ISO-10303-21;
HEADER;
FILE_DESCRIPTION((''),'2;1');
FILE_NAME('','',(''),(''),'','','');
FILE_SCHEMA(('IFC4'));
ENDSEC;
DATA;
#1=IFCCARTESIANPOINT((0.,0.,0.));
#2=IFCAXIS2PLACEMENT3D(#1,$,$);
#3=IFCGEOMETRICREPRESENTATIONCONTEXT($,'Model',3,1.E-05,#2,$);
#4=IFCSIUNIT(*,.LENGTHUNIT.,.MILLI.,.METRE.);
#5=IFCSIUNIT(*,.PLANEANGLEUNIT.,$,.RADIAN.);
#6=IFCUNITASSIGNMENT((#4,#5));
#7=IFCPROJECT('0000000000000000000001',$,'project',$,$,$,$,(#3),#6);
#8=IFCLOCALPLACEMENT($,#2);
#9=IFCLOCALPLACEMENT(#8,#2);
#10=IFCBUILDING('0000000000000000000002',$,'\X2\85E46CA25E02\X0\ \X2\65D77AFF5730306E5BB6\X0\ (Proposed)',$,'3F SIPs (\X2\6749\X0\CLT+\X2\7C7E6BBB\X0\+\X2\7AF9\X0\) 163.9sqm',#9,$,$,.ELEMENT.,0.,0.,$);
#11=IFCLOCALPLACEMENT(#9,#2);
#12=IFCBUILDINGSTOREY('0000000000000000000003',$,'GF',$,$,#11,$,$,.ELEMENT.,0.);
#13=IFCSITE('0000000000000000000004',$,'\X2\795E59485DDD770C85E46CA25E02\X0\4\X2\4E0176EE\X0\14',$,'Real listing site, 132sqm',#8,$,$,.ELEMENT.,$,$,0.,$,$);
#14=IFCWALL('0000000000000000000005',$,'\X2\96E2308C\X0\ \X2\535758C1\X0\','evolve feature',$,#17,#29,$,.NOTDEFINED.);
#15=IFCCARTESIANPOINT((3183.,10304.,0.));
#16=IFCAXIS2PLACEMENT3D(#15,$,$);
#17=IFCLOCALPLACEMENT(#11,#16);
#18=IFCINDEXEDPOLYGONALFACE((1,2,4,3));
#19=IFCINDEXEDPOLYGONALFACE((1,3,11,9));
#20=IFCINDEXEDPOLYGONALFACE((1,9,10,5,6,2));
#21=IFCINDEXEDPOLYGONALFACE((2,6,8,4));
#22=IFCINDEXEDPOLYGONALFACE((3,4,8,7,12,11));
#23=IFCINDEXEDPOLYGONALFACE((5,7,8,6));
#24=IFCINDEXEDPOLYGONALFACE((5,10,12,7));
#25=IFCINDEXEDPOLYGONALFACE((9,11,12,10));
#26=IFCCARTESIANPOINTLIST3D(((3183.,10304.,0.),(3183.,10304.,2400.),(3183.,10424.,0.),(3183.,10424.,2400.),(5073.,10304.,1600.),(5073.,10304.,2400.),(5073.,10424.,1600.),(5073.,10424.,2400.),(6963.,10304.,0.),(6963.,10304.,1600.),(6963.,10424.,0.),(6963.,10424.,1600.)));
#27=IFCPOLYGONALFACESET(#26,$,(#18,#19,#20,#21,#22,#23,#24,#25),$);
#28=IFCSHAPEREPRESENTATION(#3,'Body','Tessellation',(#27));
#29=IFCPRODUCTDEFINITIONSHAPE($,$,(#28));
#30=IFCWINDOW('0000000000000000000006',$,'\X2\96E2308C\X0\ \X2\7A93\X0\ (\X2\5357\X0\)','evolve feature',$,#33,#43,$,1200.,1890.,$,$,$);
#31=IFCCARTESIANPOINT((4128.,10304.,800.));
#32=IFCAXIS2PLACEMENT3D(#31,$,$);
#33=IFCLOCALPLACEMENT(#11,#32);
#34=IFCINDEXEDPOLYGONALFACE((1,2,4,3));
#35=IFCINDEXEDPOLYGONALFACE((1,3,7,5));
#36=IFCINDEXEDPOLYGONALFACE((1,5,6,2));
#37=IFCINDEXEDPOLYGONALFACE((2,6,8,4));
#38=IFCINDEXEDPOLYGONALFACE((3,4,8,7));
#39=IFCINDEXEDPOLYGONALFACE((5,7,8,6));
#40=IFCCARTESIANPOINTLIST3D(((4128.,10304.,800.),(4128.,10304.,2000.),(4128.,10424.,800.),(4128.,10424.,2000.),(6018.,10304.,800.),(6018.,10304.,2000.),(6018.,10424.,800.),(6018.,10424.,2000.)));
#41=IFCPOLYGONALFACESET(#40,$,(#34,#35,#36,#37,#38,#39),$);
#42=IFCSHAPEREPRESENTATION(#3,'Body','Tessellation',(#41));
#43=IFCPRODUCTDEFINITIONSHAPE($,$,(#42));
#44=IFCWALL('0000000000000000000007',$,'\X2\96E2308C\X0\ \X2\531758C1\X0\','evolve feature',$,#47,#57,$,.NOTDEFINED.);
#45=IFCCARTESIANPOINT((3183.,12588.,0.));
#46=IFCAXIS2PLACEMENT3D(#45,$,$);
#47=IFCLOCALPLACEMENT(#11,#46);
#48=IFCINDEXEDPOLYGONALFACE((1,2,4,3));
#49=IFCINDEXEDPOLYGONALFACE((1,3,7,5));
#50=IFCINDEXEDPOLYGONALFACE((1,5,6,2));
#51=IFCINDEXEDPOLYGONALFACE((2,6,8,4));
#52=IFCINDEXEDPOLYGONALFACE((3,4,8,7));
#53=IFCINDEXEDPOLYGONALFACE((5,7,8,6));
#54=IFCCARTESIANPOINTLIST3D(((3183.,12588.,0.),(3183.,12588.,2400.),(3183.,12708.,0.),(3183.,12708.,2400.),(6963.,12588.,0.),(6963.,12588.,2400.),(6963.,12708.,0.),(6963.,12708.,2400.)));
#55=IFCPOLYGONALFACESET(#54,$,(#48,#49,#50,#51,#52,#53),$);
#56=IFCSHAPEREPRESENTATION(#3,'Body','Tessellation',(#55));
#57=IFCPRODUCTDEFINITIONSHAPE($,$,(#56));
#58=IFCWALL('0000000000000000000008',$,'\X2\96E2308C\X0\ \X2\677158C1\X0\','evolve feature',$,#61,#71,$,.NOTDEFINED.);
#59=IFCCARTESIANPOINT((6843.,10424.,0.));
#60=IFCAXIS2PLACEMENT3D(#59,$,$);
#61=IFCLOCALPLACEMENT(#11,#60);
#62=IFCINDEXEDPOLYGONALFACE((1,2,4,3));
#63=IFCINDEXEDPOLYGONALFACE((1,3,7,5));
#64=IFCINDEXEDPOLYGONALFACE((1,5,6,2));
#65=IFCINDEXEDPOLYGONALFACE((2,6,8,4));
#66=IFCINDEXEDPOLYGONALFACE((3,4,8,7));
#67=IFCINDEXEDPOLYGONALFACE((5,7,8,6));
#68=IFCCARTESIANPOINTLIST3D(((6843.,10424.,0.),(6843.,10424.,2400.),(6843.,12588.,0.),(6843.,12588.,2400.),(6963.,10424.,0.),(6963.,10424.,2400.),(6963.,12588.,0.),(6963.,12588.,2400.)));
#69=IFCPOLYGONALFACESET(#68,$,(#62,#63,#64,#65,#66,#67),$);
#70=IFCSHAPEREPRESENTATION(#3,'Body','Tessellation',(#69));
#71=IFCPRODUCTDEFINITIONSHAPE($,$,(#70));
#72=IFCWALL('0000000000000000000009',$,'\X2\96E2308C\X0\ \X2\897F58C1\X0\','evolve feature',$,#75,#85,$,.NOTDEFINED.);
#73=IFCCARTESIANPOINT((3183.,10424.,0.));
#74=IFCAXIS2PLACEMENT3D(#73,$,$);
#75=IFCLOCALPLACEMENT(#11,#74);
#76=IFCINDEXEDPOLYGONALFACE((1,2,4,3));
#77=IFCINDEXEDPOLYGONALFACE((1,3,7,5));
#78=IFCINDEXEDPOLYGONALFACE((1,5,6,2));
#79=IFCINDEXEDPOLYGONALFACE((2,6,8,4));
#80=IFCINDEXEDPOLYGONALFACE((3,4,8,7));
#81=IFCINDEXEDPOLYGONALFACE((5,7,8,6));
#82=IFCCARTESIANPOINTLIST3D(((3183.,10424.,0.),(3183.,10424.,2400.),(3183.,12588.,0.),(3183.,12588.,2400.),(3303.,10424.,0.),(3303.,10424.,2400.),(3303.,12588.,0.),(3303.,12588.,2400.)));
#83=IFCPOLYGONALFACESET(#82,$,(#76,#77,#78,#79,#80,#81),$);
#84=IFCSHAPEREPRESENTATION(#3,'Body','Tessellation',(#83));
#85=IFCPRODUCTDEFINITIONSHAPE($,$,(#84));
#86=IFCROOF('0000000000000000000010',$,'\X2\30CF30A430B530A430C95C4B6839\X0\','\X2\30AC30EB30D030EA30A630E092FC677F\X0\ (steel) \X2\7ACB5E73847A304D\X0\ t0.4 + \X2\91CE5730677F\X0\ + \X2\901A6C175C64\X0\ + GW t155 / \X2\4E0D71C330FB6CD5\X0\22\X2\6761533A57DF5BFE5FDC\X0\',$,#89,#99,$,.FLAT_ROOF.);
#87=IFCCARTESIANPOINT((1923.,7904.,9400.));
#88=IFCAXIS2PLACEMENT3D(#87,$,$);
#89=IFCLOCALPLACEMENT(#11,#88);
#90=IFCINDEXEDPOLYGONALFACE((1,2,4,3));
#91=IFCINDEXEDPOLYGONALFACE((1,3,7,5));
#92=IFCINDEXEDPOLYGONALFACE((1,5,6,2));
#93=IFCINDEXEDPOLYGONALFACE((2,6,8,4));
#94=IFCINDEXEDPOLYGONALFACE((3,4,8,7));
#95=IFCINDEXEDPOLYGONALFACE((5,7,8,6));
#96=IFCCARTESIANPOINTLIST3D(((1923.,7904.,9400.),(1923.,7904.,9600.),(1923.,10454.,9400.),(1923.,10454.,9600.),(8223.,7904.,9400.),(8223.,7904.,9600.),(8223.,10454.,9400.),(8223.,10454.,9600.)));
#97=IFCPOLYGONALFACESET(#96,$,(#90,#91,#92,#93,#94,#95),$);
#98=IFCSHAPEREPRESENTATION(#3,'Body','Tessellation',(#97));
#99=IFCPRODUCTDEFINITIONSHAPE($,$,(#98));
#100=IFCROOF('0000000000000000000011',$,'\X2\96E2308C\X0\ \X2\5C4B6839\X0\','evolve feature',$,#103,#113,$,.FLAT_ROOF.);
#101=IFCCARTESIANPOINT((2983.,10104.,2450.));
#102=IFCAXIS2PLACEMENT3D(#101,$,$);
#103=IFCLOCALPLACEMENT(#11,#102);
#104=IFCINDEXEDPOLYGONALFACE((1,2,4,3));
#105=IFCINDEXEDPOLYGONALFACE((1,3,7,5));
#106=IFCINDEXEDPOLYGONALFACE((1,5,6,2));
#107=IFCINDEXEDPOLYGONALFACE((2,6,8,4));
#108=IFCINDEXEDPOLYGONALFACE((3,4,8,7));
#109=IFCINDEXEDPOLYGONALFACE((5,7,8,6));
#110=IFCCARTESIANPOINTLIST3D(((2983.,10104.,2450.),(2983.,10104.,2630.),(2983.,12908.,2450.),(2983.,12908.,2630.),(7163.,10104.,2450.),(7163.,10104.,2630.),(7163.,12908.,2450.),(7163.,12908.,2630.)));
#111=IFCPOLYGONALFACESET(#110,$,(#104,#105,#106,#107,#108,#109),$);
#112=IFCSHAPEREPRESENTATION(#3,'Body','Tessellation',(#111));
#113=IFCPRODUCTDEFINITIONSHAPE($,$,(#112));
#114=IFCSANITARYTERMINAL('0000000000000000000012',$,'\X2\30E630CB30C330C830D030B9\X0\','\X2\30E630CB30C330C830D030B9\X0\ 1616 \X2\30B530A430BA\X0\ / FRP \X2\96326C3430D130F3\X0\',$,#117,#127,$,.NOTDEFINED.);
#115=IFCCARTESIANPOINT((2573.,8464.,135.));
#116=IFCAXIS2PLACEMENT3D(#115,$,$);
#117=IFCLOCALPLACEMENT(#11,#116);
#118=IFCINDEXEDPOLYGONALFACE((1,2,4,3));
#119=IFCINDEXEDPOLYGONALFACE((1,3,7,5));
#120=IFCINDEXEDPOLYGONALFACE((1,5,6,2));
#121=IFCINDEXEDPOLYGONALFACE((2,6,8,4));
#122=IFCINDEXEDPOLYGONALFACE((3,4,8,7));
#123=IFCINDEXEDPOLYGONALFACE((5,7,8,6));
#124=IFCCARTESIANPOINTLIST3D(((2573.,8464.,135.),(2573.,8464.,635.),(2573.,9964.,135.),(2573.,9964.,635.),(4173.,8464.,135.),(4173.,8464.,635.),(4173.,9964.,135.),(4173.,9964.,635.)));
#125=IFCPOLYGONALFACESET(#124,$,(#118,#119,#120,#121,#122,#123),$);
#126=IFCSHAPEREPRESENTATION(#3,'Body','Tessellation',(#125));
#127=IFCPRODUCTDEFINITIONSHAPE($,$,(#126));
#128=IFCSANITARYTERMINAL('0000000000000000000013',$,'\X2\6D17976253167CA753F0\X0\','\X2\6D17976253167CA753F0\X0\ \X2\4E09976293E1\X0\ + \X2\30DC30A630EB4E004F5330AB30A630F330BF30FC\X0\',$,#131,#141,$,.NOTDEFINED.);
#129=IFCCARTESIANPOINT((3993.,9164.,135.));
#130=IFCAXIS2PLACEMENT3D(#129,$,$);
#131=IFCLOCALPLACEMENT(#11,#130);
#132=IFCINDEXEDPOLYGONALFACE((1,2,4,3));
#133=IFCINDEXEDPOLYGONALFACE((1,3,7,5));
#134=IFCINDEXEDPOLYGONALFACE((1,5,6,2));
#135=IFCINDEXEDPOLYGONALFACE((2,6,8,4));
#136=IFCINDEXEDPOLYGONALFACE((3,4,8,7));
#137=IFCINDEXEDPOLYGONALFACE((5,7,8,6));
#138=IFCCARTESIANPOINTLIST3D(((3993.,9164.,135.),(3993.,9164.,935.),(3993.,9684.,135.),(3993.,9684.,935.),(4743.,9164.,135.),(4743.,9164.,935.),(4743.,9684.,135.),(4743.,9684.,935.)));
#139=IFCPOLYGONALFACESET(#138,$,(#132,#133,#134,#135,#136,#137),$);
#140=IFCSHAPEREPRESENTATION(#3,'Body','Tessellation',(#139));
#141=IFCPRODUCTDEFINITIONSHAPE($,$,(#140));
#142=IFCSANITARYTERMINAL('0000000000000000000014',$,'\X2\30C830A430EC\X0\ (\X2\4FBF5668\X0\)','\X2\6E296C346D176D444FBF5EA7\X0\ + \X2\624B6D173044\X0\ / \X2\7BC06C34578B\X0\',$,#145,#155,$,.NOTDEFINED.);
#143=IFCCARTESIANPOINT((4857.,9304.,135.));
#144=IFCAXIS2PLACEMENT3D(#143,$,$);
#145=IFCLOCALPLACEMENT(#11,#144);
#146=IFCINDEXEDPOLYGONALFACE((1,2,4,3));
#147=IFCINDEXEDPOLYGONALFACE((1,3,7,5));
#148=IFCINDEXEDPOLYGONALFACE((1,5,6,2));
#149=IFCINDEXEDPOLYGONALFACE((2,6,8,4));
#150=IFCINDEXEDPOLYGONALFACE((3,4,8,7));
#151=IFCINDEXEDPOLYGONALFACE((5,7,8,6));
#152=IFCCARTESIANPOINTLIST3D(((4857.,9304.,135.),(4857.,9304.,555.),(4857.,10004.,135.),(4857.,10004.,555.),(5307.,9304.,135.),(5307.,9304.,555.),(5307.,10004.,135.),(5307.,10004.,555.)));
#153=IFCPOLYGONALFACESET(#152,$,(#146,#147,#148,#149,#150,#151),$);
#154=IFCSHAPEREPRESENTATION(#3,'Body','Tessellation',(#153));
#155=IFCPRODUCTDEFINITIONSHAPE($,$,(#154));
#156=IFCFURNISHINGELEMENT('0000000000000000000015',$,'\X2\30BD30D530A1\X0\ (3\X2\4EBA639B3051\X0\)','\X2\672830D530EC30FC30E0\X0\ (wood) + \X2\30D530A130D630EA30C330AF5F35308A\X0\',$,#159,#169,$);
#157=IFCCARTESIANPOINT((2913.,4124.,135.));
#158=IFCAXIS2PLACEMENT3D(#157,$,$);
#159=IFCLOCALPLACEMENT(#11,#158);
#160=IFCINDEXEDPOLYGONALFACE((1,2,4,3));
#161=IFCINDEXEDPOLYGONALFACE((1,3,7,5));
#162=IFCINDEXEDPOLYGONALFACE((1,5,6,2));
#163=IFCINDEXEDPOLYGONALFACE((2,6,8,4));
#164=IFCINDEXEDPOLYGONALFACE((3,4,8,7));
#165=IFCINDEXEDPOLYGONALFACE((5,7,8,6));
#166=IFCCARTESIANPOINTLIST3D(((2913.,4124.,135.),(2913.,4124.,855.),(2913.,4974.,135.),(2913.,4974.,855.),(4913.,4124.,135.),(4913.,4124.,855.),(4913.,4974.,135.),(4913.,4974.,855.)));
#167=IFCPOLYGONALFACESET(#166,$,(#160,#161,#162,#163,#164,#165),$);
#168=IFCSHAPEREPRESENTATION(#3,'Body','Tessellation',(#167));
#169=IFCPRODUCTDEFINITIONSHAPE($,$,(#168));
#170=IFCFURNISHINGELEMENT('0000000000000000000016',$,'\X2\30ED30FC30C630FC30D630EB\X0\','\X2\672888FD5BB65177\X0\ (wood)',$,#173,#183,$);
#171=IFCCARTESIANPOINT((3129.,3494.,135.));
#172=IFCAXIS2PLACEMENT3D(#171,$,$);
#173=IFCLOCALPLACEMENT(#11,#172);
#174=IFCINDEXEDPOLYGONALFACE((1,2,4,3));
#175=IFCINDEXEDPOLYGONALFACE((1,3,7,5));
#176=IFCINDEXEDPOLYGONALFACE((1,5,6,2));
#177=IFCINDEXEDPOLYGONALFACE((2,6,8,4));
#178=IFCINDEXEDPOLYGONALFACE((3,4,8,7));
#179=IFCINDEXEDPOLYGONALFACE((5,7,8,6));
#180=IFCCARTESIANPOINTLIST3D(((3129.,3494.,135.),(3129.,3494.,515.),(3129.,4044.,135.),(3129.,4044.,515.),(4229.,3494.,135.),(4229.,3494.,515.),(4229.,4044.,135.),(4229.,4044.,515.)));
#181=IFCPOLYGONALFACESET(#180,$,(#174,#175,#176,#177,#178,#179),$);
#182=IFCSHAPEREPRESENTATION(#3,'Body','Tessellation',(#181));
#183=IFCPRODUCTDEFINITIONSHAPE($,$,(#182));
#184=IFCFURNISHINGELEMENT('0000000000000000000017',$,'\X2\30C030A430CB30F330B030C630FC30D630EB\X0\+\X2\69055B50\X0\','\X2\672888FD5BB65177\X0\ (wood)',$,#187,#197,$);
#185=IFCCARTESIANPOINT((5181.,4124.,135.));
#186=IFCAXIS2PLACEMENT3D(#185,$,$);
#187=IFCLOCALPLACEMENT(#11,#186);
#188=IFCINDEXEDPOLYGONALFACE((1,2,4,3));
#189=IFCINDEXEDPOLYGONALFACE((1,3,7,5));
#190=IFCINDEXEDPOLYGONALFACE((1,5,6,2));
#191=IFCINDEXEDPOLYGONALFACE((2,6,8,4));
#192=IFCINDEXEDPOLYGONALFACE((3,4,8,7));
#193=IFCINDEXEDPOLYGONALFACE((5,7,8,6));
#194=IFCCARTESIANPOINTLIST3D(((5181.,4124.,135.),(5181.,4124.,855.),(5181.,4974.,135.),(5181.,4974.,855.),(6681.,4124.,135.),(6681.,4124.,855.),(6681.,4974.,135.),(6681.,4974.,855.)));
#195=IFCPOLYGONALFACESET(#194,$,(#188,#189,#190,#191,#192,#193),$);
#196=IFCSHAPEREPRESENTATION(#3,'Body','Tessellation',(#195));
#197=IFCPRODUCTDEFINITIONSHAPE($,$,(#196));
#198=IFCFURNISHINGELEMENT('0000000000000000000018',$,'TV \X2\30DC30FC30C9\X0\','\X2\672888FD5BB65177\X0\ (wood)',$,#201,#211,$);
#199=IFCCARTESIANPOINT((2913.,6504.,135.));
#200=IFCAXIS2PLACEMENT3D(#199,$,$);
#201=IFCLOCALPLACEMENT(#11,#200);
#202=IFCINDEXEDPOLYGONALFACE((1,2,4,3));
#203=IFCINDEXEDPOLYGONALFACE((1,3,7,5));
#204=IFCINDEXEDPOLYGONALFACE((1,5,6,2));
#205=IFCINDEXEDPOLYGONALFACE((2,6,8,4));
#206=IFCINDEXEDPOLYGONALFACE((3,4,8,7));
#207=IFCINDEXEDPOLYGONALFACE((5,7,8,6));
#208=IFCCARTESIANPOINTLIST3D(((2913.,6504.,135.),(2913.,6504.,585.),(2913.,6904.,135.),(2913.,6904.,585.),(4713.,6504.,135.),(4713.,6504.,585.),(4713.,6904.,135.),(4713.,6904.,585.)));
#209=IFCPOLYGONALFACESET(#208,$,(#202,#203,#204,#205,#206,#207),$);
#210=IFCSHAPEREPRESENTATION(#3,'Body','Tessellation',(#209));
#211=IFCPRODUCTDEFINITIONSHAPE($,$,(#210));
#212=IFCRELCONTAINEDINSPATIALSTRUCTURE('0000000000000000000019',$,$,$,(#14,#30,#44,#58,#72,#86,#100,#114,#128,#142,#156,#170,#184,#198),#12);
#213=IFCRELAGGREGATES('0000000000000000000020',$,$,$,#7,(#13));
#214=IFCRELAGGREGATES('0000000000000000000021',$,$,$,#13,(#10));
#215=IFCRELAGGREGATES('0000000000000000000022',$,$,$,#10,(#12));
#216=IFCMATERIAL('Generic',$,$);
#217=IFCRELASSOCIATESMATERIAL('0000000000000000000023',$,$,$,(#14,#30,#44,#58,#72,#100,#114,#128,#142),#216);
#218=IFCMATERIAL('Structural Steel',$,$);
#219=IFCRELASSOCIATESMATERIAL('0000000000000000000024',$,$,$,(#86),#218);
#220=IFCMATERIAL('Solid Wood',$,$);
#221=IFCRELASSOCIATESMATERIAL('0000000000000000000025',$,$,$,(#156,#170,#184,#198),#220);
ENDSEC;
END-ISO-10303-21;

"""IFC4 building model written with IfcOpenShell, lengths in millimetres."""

from ifc_helpers import new_model, si_unit, frame, frame_2d, origin, place, context, project, spatial, rectangle, extrude, material, element, fill, save


model = new_model("IFC4")

# Units and contexts
model_context = context("Model", 3, precision=1e-05, world=origin())
ifc_project = project(units=[si_unit("LENGTHUNIT", "METRE", prefix="MILLI"), si_unit("PLANEANGLEUNIT", "RADIAN")], contexts=[model_context])

# Site, building, storey
site_placement = place(None, origin())
site = spatial("IfcSite", under=ifc_project, at=site_placement, Name="神奈川県藤沢市4丁目14", ObjectType="Real listing site, 132sqm", CompositionType="ELEMENT", RefElevation=0.0)
building_placement = place(site_placement, origin())
building = spatial("IfcBuilding", under=site, at=building_placement, Name="藤沢市 旗竿地の家 (Proposed)", ObjectType="3F SIPs (杉CLT+籾殻+竹) 163.9sqm", CompositionType="ELEMENT", ElevationOfRefHeight=0.0, ElevationOfTerrain=0.0)
storey_placement = place(building_placement, origin())
storey = spatial("IfcBuildingStorey", under=building, at=storey_placement, Name="GF", CompositionType="ELEMENT", Elevation=0.0)

# Shared definitions
ifc_material_1 = material(Name="Generic")

# Shared definitions
ifc_material_2 = material(Name="Solid Wood")

# Wall, opening, window
wall_1_placement = place(storey_placement, frame((3183.0, 10304.0, 0.0)))
wall_1 = element("IfcWall", 1, at=wall_1_placement, inside=storey, material=ifc_material_1, Name="離れ 南壁", Description="evolve feature", PredefinedType="NOTDEFINED", context=model_context, shape_type="SweptSolid", body=[
    extrude(rectangle(XDim=3780.0, YDim=120.0, at=frame_2d((1890.0, 60.0))), frame((3183.0, 10304.0, 0.0)), (0.0, 0.0, 1.0), 2400.0),
])
opening_1_placement = place(storey_placement, frame((4128.0, 10304.0, 800.0)))
opening_1 = element("IfcOpeningElement", 2, at=opening_1_placement, cuts=wall_1, PredefinedType="NOTDEFINED", context=model_context, shape_type="SweptSolid", body=[
    extrude(rectangle(XDim=1890.0, YDim=120.0, at=frame_2d((945.0, 60.0))), frame((4128.0, 10304.0, 800.0)), (0.0, 0.0, 1.0), 1200.0),
])
window_1_placement = place(storey_placement, frame((4128.0, 10304.0, 800.0)))
window_1 = element("IfcWindow", 3, at=window_1_placement, inside=storey, material=ifc_material_1, Name="離れ 窓 (南)", Description="evolve feature", OverallHeight=1200.0, OverallWidth=1890.0, context=model_context, shape_type="SweptSolid", body=[
    extrude(rectangle(XDim=1890.0, YDim=120.0, at=frame_2d((945.0, 60.0))), frame((4128.0, 10304.0, 800.0)), (0.0, 0.0, 1.0), 1200.0),
])
fill(opening_1, window_1)

# Walls
wall_2_placement = place(storey_placement, frame((3183.0, 12588.0, 0.0)))
element("IfcWall", 4, at=wall_2_placement, inside=storey, material=ifc_material_1, Name="離れ 北壁", Description="evolve feature", PredefinedType="NOTDEFINED", context=model_context, shape_type="SweptSolid", body=[
    extrude(rectangle(XDim=3780.0, YDim=120.0, at=frame_2d((1890.0, 60.0))), frame((3183.0, 12588.0, 0.0)), (0.0, 0.0, 1.0), 2400.0),
])
wall_3_placement = place(storey_placement, frame((6843.0, 10424.0, 0.0)))
element("IfcWall", 5, at=wall_3_placement, inside=storey, material=ifc_material_1, Name="離れ 東壁", Description="evolve feature", PredefinedType="NOTDEFINED", context=model_context, shape_type="SweptSolid", body=[
    extrude(rectangle(XDim=120.0, YDim=2164.0, at=frame_2d((60.0, 1082.0))), frame((6843.0, 10424.0, 0.0)), (0.0, 0.0, 1.0), 2400.0),
])
wall_4_placement = place(storey_placement, frame((3183.0, 10424.0, 0.0)))
element("IfcWall", 6, at=wall_4_placement, inside=storey, material=ifc_material_1, Name="離れ 西壁", Description="evolve feature", PredefinedType="NOTDEFINED", context=model_context, shape_type="SweptSolid", body=[
    extrude(rectangle(XDim=120.0, YDim=2164.0, at=frame_2d((60.0, 1082.0))), frame((3183.0, 10424.0, 0.0)), (0.0, 0.0, 1.0), 2400.0),
])

# Roofs
ifc_material_3 = material(Name="Structural Steel")
roof_1_placement = place(storey_placement, frame((1923.0, 7904.0, 9400.0)))
element("IfcRoof", 7, at=roof_1_placement, inside=storey, material=ifc_material_3, Name="ハイサイド屋根", Description="ガルバリウム鋼板 (steel) 立平葺き t0.4 + 野地板 + 通気層 + GW t155 / 不燃・法22条区域対応", PredefinedType="FLAT_ROOF", context=model_context, shape_type="SweptSolid", body=[
    extrude(rectangle(XDim=6300.0, YDim=2550.0, at=frame_2d((3150.0, 1275.0))), frame((1923.0, 7904.0, 9400.0)), (0.0, 0.0, 1.0), 200.0),
])
roof_2_placement = place(storey_placement, frame((2983.0, 10104.0, 2450.0)))
element("IfcRoof", 8, at=roof_2_placement, inside=storey, material=ifc_material_1, Name="離れ 屋根", Description="evolve feature", PredefinedType="FLAT_ROOF", context=model_context, shape_type="SweptSolid", body=[
    extrude(rectangle(XDim=4180.0, YDim=2804.0, at=frame_2d((2090.0, 1402.0))), frame((2983.0, 10104.0, 2450.0)), (0.0, 0.0, 1.0), 180.0),
])

# Sanitary terminals
sanitary_terminal_1_placement = place(storey_placement, frame((2573.0, 8464.0, 135.0)))
element("IfcSanitaryTerminal", 9, at=sanitary_terminal_1_placement, inside=storey, material=ifc_material_1, Name="ユニットバス", Description="ユニットバス 1616 サイズ / FRP 防水パン", PredefinedType="NOTDEFINED", context=model_context, shape_type="SweptSolid", body=[
    extrude(rectangle(XDim=1600.0, YDim=1500.0, at=frame_2d((800.0, 750.0))), frame((2573.0, 8464.0, 135.0)), (0.0, 0.0, 1.0), 500.0),
])
sanitary_terminal_2_placement = place(storey_placement, frame((3993.0, 9164.0, 135.0)))
element("IfcSanitaryTerminal", 10, at=sanitary_terminal_2_placement, inside=storey, material=ifc_material_1, Name="洗面化粧台", Description="洗面化粧台 三面鏡 + ボウル一体カウンター", PredefinedType="NOTDEFINED", context=model_context, shape_type="SweptSolid", body=[
    extrude(rectangle(XDim=750.0, YDim=520.0, at=frame_2d((375.0, 260.0))), frame((3993.0, 9164.0, 135.0)), (0.0, 0.0, 1.0), 800.0),
])
sanitary_terminal_3_placement = place(storey_placement, frame((4857.0, 9304.0, 135.0)))
element("IfcSanitaryTerminal", 11, at=sanitary_terminal_3_placement, inside=storey, material=ifc_material_1, Name="トイレ (便器)", Description="温水洗浄便座 + 手洗い / 節水型", PredefinedType="NOTDEFINED", context=model_context, shape_type="SweptSolid", body=[
    extrude(rectangle(XDim=450.0, YDim=700.0, at=frame_2d((225.0, 350.0))), frame((4857.0, 9304.0, 135.0)), (0.0, 0.0, 1.0), 420.0),
])

# Furnishing elements
furnishing_1_placement = place(storey_placement, frame((2913.0, 4124.0, 135.0)))
element("IfcFurnishingElement", 12, at=furnishing_1_placement, inside=storey, material=ifc_material_2, Name="ソファ (3人掛け)", Description="木フレーム (wood) + ファブリック張り", context=model_context, shape_type="SweptSolid", body=[
    extrude(rectangle(XDim=2000.0, YDim=850.0, at=frame_2d((1000.0, 425.0))), frame((2913.0, 4124.0, 135.0)), (0.0, 0.0, 1.0), 720.0),
])
furnishing_2_placement = place(storey_placement, frame((3129.0, 3494.0, 135.0)))
element("IfcFurnishingElement", 13, at=furnishing_2_placement, inside=storey, material=ifc_material_2, Name="ローテーブル", Description="木製家具 (wood)", context=model_context, shape_type="SweptSolid", body=[
    extrude(rectangle(XDim=1100.0, YDim=550.0, at=frame_2d((550.0, 275.0))), frame((3129.0, 3494.0, 135.0)), (0.0, 0.0, 1.0), 380.0),
])
furnishing_3_placement = place(storey_placement, frame((5181.0, 4124.0, 135.0)))
element("IfcFurnishingElement", 14, at=furnishing_3_placement, inside=storey, material=ifc_material_2, Name="ダイニングテーブル+椅子", Description="木製家具 (wood)", context=model_context, shape_type="SweptSolid", body=[
    extrude(rectangle(XDim=1500.0, YDim=850.0, at=frame_2d((750.0, 425.0))), frame((5181.0, 4124.0, 135.0)), (0.0, 0.0, 1.0), 720.0),
])
furnishing_4_placement = place(storey_placement, frame((2913.0, 6504.0, 135.0)))
element("IfcFurnishingElement", 15, at=furnishing_4_placement, inside=storey, material=ifc_material_2, Name="TV ボード", Description="木製家具 (wood)", context=model_context, shape_type="SweptSolid", body=[
    extrude(rectangle(XDim=1800.0, YDim=400.0, at=frame_2d((900.0, 200.0))), frame((2913.0, 6504.0, 135.0)), (0.0, 0.0, 1.0), 450.0),
])

save(model, "model.ifc")
